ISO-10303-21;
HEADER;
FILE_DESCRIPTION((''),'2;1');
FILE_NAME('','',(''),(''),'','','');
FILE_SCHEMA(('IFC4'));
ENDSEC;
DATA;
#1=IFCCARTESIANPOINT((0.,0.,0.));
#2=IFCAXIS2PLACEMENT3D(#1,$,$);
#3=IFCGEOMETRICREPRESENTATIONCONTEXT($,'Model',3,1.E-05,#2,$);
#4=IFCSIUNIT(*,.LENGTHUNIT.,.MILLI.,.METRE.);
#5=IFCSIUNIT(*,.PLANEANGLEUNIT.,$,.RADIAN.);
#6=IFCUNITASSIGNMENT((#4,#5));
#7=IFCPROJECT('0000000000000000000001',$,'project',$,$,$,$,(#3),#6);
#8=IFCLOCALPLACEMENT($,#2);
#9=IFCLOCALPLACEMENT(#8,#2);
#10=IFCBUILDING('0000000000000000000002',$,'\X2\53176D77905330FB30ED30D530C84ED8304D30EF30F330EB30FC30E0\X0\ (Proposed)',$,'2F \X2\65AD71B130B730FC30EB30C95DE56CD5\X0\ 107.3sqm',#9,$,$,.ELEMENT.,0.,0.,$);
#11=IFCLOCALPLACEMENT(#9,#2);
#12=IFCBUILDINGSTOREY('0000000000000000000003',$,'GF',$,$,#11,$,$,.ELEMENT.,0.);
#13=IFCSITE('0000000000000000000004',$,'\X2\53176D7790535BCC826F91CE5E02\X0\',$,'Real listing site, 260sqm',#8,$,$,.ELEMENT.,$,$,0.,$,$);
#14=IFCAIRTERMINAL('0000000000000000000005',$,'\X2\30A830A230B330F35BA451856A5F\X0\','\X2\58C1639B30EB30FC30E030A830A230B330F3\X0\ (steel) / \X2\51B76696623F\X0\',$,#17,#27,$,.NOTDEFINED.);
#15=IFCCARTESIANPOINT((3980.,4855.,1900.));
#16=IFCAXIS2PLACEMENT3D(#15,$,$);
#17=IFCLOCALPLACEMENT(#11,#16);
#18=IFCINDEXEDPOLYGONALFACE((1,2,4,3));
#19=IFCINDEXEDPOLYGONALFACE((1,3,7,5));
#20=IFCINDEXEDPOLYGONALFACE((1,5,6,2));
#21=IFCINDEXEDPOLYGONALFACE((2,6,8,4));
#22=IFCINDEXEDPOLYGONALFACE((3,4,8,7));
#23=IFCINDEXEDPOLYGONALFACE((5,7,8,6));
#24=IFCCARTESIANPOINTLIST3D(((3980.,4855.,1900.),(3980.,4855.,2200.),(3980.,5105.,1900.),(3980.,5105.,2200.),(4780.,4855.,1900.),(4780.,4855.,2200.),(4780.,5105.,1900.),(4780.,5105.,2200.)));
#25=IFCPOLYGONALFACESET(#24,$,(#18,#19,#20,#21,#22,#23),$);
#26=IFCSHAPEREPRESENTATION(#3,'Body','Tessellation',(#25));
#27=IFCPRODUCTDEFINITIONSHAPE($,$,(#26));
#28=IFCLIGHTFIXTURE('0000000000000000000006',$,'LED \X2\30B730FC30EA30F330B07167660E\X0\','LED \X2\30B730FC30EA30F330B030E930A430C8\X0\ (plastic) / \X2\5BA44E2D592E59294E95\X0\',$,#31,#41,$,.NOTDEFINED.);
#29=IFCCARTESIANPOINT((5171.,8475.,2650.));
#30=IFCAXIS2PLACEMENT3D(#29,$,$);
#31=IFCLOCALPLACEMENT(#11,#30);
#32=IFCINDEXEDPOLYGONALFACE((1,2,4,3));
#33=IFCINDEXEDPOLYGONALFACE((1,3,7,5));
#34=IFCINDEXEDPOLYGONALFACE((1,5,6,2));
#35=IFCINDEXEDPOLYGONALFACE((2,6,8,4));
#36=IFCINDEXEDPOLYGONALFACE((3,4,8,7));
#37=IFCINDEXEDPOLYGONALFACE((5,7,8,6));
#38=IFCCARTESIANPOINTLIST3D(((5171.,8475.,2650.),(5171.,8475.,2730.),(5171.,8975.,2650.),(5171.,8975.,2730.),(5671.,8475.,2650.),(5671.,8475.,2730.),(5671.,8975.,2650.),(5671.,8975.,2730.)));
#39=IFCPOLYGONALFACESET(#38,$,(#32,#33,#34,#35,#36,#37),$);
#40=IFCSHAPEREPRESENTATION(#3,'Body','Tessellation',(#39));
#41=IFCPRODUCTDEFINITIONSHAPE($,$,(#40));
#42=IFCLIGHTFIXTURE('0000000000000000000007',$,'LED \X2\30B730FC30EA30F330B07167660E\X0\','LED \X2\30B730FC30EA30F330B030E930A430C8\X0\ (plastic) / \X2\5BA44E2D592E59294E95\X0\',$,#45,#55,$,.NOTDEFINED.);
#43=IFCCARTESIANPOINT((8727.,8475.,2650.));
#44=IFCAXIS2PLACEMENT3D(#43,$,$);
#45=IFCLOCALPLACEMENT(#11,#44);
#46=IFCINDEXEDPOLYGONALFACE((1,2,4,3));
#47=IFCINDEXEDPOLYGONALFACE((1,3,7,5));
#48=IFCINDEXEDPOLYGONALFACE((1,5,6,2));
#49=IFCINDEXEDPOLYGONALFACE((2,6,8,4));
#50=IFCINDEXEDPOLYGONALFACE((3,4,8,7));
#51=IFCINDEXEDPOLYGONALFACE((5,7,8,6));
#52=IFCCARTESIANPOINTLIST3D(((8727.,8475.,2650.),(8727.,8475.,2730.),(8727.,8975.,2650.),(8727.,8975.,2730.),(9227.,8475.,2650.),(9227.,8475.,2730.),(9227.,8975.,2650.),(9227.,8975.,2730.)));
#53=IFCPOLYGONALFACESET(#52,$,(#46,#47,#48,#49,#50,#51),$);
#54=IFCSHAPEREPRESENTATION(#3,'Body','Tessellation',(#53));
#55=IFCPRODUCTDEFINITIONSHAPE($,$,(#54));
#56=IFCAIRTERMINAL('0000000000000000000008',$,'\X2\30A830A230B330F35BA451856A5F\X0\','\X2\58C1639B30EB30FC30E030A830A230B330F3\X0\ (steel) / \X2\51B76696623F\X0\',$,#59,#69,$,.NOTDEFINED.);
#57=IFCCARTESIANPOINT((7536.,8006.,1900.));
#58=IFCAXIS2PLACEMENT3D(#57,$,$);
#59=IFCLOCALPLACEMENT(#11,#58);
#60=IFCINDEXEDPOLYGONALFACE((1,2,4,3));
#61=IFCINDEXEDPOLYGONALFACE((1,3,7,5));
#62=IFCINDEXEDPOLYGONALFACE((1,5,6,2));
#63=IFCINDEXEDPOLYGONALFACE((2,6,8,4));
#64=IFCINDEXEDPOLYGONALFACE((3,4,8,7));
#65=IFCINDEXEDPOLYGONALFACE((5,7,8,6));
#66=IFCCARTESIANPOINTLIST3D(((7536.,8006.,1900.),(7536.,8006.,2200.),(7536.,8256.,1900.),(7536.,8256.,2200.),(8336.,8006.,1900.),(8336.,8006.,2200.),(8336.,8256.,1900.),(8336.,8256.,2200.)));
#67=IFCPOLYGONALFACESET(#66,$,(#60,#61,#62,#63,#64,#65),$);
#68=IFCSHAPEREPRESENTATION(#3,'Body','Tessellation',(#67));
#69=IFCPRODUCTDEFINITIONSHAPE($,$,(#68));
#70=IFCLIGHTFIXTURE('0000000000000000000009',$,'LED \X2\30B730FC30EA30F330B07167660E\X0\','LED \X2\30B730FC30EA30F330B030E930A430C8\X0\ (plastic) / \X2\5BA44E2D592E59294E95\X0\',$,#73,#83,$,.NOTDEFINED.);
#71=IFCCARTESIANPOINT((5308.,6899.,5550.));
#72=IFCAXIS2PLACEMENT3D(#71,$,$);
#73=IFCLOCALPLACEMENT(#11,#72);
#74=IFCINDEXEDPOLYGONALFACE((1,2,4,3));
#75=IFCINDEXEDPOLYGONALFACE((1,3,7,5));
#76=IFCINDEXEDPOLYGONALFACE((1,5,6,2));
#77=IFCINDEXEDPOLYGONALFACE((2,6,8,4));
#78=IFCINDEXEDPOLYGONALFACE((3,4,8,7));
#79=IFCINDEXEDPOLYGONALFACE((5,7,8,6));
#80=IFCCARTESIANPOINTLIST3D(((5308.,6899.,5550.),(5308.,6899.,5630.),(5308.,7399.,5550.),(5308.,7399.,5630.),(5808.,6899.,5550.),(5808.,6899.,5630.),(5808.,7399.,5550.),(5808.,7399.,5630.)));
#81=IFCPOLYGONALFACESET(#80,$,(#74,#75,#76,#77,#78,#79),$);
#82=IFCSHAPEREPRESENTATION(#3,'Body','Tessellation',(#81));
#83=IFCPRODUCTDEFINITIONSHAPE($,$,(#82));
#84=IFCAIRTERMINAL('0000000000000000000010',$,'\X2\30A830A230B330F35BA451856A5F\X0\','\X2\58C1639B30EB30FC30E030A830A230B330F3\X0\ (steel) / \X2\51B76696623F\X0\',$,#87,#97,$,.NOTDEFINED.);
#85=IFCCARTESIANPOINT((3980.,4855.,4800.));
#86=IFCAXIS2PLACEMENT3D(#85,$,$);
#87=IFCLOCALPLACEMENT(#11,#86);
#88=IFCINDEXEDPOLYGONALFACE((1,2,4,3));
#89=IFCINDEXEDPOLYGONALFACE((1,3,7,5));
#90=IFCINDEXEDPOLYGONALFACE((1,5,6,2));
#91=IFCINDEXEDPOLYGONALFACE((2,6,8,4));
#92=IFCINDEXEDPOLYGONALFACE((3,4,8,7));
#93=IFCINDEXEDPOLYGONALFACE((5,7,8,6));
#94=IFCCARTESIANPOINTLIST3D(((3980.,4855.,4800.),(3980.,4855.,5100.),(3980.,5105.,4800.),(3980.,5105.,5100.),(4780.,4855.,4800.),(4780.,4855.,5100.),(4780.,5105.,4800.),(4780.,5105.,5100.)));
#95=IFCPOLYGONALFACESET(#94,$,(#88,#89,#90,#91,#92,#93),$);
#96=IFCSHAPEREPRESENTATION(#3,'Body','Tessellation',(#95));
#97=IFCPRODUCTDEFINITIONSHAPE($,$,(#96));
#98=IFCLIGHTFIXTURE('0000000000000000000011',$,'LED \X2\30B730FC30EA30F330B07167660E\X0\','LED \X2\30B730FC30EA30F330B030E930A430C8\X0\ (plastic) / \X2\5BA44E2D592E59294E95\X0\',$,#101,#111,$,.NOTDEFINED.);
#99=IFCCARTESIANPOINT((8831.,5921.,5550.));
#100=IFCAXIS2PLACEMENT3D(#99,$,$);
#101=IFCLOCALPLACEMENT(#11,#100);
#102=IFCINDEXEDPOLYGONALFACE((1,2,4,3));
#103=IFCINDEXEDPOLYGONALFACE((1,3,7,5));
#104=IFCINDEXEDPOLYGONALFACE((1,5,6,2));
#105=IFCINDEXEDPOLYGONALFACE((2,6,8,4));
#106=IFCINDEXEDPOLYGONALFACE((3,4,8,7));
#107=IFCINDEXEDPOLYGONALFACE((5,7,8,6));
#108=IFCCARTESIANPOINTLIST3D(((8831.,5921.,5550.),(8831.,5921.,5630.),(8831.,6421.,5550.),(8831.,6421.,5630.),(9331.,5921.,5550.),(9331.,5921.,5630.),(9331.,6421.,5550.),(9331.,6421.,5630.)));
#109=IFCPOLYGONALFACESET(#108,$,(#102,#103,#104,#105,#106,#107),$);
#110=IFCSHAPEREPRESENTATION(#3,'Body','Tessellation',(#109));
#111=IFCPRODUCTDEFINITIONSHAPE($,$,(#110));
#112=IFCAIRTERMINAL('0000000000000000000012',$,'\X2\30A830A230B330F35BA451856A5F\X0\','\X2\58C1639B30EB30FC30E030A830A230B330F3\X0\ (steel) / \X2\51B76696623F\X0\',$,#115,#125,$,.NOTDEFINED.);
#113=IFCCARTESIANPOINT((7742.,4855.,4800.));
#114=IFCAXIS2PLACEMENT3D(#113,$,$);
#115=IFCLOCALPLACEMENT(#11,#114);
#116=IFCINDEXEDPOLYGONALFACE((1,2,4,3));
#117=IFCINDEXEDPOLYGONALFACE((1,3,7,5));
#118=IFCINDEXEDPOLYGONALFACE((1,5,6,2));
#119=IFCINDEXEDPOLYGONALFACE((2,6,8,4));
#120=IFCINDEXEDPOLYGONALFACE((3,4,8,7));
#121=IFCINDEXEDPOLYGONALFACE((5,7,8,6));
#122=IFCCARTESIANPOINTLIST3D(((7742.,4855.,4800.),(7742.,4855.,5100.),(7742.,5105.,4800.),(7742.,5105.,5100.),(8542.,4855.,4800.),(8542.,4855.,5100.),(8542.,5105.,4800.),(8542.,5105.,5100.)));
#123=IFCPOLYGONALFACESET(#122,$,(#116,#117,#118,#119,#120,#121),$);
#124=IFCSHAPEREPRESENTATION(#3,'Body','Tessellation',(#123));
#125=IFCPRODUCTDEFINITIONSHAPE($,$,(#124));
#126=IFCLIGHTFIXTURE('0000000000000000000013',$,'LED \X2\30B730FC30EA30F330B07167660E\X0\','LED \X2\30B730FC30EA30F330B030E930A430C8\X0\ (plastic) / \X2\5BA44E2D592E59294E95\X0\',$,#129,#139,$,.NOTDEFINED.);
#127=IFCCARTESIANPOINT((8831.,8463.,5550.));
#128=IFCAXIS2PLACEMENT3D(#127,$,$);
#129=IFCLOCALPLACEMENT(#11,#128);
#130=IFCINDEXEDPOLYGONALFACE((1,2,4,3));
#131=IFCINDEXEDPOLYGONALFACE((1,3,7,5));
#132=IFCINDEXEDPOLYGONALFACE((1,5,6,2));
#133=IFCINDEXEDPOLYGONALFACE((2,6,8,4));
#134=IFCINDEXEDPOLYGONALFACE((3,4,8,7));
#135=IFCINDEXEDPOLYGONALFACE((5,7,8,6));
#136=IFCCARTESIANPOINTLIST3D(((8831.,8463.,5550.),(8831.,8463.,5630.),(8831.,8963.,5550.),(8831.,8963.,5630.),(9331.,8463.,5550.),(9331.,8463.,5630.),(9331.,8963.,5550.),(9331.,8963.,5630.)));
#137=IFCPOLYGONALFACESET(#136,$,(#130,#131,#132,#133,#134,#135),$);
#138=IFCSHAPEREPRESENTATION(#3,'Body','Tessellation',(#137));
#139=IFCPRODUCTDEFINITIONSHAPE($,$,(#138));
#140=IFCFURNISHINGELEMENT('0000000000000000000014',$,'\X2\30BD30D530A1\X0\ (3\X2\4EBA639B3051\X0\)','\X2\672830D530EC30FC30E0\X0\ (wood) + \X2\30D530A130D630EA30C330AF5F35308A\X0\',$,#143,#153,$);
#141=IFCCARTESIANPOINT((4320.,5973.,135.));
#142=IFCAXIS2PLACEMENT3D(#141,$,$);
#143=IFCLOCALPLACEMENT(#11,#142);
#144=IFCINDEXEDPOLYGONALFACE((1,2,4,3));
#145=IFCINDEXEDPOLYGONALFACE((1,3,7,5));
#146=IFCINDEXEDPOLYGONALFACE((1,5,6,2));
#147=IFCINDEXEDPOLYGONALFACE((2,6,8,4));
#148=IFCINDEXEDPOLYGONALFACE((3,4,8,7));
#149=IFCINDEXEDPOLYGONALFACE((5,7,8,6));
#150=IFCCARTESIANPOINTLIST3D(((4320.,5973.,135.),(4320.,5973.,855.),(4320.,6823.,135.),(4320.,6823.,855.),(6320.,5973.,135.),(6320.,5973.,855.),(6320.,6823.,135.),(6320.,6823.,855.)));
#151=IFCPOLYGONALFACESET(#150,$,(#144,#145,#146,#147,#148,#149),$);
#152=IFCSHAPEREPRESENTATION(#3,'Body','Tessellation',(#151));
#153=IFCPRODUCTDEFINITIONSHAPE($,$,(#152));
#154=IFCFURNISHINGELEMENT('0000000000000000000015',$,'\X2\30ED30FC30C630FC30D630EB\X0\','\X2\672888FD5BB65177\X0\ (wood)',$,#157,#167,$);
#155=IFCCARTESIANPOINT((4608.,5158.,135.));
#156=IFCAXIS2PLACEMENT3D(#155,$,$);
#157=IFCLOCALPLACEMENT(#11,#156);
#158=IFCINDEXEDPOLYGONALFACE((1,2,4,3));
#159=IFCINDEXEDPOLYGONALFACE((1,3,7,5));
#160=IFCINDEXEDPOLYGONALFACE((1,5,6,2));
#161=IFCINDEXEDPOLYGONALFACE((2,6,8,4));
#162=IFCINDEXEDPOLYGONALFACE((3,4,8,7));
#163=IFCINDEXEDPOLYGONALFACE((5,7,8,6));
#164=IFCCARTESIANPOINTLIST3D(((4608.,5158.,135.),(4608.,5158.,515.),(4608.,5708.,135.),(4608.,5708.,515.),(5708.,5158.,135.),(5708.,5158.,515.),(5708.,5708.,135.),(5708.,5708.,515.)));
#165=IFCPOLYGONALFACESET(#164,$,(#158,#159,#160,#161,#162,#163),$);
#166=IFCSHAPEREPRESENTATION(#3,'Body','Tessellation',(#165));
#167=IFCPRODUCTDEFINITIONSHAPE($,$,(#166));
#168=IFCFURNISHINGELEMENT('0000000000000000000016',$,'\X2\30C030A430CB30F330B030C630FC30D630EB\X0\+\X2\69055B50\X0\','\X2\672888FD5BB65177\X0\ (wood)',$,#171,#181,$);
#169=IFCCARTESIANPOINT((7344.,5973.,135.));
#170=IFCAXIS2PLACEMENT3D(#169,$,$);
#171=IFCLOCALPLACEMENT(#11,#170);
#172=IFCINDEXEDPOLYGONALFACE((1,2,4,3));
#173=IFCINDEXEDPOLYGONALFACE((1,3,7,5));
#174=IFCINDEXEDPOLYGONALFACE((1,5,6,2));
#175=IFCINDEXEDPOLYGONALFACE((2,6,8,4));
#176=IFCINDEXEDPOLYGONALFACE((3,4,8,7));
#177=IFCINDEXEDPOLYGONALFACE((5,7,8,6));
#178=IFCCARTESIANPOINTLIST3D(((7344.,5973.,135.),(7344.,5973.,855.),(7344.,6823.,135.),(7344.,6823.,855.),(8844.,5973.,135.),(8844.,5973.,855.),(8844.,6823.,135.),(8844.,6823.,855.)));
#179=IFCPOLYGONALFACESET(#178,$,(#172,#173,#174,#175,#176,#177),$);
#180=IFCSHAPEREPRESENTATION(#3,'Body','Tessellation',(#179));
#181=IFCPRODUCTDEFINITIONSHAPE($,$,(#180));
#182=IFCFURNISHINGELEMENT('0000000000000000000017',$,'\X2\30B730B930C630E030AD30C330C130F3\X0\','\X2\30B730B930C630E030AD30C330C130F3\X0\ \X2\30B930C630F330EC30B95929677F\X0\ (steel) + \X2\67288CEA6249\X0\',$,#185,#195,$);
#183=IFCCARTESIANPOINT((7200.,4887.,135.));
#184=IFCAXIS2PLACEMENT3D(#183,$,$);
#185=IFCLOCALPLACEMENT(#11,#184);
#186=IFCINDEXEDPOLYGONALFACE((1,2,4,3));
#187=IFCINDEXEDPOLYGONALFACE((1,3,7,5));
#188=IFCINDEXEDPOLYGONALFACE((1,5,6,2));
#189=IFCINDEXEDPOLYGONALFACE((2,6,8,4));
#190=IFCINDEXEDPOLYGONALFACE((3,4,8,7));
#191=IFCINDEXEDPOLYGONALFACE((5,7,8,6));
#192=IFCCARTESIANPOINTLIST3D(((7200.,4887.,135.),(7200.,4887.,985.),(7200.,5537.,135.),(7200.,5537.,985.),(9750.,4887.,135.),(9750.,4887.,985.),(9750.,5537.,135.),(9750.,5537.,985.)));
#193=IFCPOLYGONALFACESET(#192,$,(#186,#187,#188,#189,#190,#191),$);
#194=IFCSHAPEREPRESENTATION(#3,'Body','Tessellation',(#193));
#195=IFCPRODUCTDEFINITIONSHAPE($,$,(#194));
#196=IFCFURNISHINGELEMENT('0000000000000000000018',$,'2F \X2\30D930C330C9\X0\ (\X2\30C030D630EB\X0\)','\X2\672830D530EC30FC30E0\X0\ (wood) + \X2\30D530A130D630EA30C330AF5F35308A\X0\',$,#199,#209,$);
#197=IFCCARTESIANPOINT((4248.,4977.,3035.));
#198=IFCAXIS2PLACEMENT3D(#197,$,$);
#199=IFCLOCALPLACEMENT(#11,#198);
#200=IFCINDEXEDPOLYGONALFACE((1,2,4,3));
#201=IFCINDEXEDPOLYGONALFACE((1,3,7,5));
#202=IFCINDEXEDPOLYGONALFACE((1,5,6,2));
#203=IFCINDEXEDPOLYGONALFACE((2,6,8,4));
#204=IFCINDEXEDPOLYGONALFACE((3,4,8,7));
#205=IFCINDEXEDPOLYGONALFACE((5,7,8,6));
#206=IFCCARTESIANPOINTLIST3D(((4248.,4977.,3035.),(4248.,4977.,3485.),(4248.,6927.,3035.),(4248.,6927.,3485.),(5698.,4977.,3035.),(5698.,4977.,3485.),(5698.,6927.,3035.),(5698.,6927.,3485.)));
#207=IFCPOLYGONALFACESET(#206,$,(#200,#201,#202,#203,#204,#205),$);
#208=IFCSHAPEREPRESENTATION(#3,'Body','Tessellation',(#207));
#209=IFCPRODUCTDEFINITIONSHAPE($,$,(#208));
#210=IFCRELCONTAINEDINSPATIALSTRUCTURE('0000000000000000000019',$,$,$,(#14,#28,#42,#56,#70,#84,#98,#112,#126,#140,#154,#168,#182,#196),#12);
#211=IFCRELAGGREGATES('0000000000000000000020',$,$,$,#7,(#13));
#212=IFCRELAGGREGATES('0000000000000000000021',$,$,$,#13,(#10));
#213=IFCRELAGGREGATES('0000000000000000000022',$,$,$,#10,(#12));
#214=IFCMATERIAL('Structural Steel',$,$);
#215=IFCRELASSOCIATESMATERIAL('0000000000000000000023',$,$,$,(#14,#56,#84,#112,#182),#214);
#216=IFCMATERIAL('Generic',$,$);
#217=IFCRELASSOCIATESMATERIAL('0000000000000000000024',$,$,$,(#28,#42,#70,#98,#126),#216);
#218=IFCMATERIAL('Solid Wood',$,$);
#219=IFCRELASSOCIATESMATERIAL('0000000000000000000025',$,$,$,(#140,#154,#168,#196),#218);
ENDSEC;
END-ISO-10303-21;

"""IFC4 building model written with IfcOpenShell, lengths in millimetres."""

from ifc_helpers import new_model, si_unit, frame, frame_2d, origin, place, context, project, spatial, rectangle, extrude, material, element, save


model = new_model("IFC4")

# Units and contexts
model_context = context("Model", 3, precision=1e-05, world=origin())
ifc_project = project(units=[si_unit("LENGTHUNIT", "METRE", prefix="MILLI"), si_unit("PLANEANGLEUNIT", "RADIAN")], contexts=[model_context])

# Site, building, storey
site_placement = place(None, origin())
site = spatial("IfcSite", under=ifc_project, at=site_placement, Name="北海道富良野市", ObjectType="Real listing site, 260sqm", CompositionType="ELEMENT", RefElevation=0.0)
building_placement = place(site_placement, origin())
building = spatial("IfcBuilding", under=site, at=building_placement, Name="北海道・ロフト付きワンルーム (Proposed)", ObjectType="2F 断熱シールド工法 107.3sqm", CompositionType="ELEMENT", ElevationOfRefHeight=0.0, ElevationOfTerrain=0.0)
storey_placement = place(building_placement, origin())
storey = spatial("IfcBuildingStorey", under=building, at=storey_placement, Name="GF", CompositionType="ELEMENT", Elevation=0.0)

# Shared definitions
ifc_material_1 = material(Name="Solid Wood")

# Shared definitions
ifc_material_2 = material(Name="Structural Steel")

# Shared definitions
ifc_material_3 = material(Name="Generic")

# Air terminal
air_terminal_1_placement = place(storey_placement, frame((3980.0, 4855.0, 1900.0)))
element("IfcAirTerminal", 1, at=air_terminal_1_placement, inside=storey, material=ifc_material_2, Name="エアコン室内機", Description="壁掛ルームエアコン (steel) / 冷暖房", PredefinedType="NOTDEFINED", context=model_context, shape_type="SweptSolid", body=[
    extrude(rectangle(XDim=800.0, YDim=250.0, at=frame_2d((400.0, 125.0))), frame((3980.0, 4855.0, 1900.0)), (0.0, 0.0, 1.0), 300.0),
])

# Light fixtures
light_fixture_1_placement = place(storey_placement, frame((5171.0, 8475.0, 2650.0)))
element("IfcLightFixture", 2, at=light_fixture_1_placement, inside=storey, material=ifc_material_3, Name="LED シーリング照明", Description="LED シーリングライト (plastic) / 室中央天井", PredefinedType="NOTDEFINED", context=model_context, shape_type="SweptSolid", body=[
    extrude(rectangle(XDim=500.0, YDim=500.0, at=frame_2d((250.0, 250.0))), frame((5171.0, 8475.0, 2650.0)), (0.0, 0.0, 1.0), 80.0),
])
light_fixture_2_placement = place(storey_placement, frame((8727.0, 8475.0, 2650.0)))
element("IfcLightFixture", 3, at=light_fixture_2_placement, inside=storey, material=ifc_material_3, Name="LED シーリング照明", Description="LED シーリングライト (plastic) / 室中央天井", PredefinedType="NOTDEFINED", context=model_context, shape_type="SweptSolid", body=[
    extrude(rectangle(XDim=500.0, YDim=500.0, at=frame_2d((250.0, 250.0))), frame((8727.0, 8475.0, 2650.0)), (0.0, 0.0, 1.0), 80.0),
])

# Air terminal
air_terminal_2_placement = place(storey_placement, frame((7536.0, 8006.0, 1900.0)))
element("IfcAirTerminal", 4, at=air_terminal_2_placement, inside=storey, material=ifc_material_2, Name="エアコン室内機", Description="壁掛ルームエアコン (steel) / 冷暖房", PredefinedType="NOTDEFINED", context=model_context, shape_type="SweptSolid", body=[
    extrude(rectangle(XDim=800.0, YDim=250.0, at=frame_2d((400.0, 125.0))), frame((7536.0, 8006.0, 1900.0)), (0.0, 0.0, 1.0), 300.0),
])

# Light fixture
light_fixture_3_placement = place(storey_placement, frame((5308.0, 6899.0, 5550.0)))
element("IfcLightFixture", 5, at=light_fixture_3_placement, inside=storey, material=ifc_material_3, Name="LED シーリング照明", Description="LED シーリングライト (plastic) / 室中央天井", PredefinedType="NOTDEFINED", context=model_context, shape_type="SweptSolid", body=[
    extrude(rectangle(XDim=500.0, YDim=500.0, at=frame_2d((250.0, 250.0))), frame((5308.0, 6899.0, 5550.0)), (0.0, 0.0, 1.0), 80.0),
])

# Air terminal
air_terminal_3_placement = place(storey_placement, frame((3980.0, 4855.0, 4800.0)))
element("IfcAirTerminal", 6, at=air_terminal_3_placement, inside=storey, material=ifc_material_2, Name="エアコン室内機", Description="壁掛ルームエアコン (steel) / 冷暖房", PredefinedType="NOTDEFINED", context=model_context, shape_type="SweptSolid", body=[
    extrude(rectangle(XDim=800.0, YDim=250.0, at=frame_2d((400.0, 125.0))), frame((3980.0, 4855.0, 4800.0)), (0.0, 0.0, 1.0), 300.0),
])

# Light fixture
light_fixture_4_placement = place(storey_placement, frame((8831.0, 5921.0, 5550.0)))
element("IfcLightFixture", 7, at=light_fixture_4_placement, inside=storey, material=ifc_material_3, Name="LED シーリング照明", Description="LED シーリングライト (plastic) / 室中央天井", PredefinedType="NOTDEFINED", context=model_context, shape_type="SweptSolid", body=[
    extrude(rectangle(XDim=500.0, YDim=500.0, at=frame_2d((250.0, 250.0))), frame((8831.0, 5921.0, 5550.0)), (0.0, 0.0, 1.0), 80.0),
])

# Air terminal
air_terminal_4_placement = place(storey_placement, frame((7742.0, 4855.0, 4800.0)))
element("IfcAirTerminal", 8, at=air_terminal_4_placement, inside=storey, material=ifc_material_2, Name="エアコン室内機", Description="壁掛ルームエアコン (steel) / 冷暖房", PredefinedType="NOTDEFINED", context=model_context, shape_type="SweptSolid", body=[
    extrude(rectangle(XDim=800.0, YDim=250.0, at=frame_2d((400.0, 125.0))), frame((7742.0, 4855.0, 4800.0)), (0.0, 0.0, 1.0), 300.0),
])

# Light fixture
light_fixture_5_placement = place(storey_placement, frame((8831.0, 8463.0, 5550.0)))
element("IfcLightFixture", 9, at=light_fixture_5_placement, inside=storey, material=ifc_material_3, Name="LED シーリング照明", Description="LED シーリングライト (plastic) / 室中央天井", PredefinedType="NOTDEFINED", context=model_context, shape_type="SweptSolid", body=[
    extrude(rectangle(XDim=500.0, YDim=500.0, at=frame_2d((250.0, 250.0))), frame((8831.0, 8463.0, 5550.0)), (0.0, 0.0, 1.0), 80.0),
])

# Furnishing elements
furnishing_1_placement = place(storey_placement, frame((4320.0, 5973.0, 135.0)))
element("IfcFurnishingElement", 10, at=furnishing_1_placement, inside=storey, material=ifc_material_1, Name="ソファ (3人掛け)", Description="木フレーム (wood) + ファブリック張り", context=model_context, shape_type="SweptSolid", body=[
    extrude(rectangle(XDim=2000.0, YDim=850.0, at=frame_2d((1000.0, 425.0))), frame((4320.0, 5973.0, 135.0)), (0.0, 0.0, 1.0), 720.0),
])
furnishing_2_placement = place(storey_placement, frame((4608.0, 5158.0, 135.0)))
element("IfcFurnishingElement", 11, at=furnishing_2_placement, inside=storey, material=ifc_material_1, Name="ローテーブル", Description="木製家具 (wood)", context=model_context, shape_type="SweptSolid", body=[
    extrude(rectangle(XDim=1100.0, YDim=550.0, at=frame_2d((550.0, 275.0))), frame((4608.0, 5158.0, 135.0)), (0.0, 0.0, 1.0), 380.0),
])
furnishing_3_placement = place(storey_placement, frame((7344.0, 5973.0, 135.0)))
element("IfcFurnishingElement", 12, at=furnishing_3_placement, inside=storey, material=ifc_material_1, Name="ダイニングテーブル+椅子", Description="木製家具 (wood)", context=model_context, shape_type="SweptSolid", body=[
    extrude(rectangle(XDim=1500.0, YDim=850.0, at=frame_2d((750.0, 425.0))), frame((7344.0, 5973.0, 135.0)), (0.0, 0.0, 1.0), 720.0),
])
furnishing_4_placement = place(storey_placement, frame((7200.0, 4887.0, 135.0)))
element("IfcFurnishingElement", 13, at=furnishing_4_placement, inside=storey, material=ifc_material_2, Name="システムキッチン", Description="システムキッチン ステンレス天板 (steel) + 木質扉", context=model_context, shape_type="SweptSolid", body=[
    extrude(rectangle(XDim=2550.0, YDim=650.0, at=frame_2d((1275.0, 325.0))), frame((7200.0, 4887.0, 135.0)), (0.0, 0.0, 1.0), 850.0),
])
furnishing_5_placement = place(storey_placement, frame((4248.0, 4977.0, 3035.0)))
element("IfcFurnishingElement", 14, at=furnishing_5_placement, inside=storey, material=ifc_material_1, Name="2F ベッド (ダブル)", Description="木フレーム (wood) + ファブリック張り", context=model_context, shape_type="SweptSolid", body=[
    extrude(rectangle(XDim=1450.0, YDim=1950.0, at=frame_2d((725.0, 975.0))), frame((4248.0, 4977.0, 3035.0)), (0.0, 0.0, 1.0), 450.0),
])

save(model, "model.ifc")
